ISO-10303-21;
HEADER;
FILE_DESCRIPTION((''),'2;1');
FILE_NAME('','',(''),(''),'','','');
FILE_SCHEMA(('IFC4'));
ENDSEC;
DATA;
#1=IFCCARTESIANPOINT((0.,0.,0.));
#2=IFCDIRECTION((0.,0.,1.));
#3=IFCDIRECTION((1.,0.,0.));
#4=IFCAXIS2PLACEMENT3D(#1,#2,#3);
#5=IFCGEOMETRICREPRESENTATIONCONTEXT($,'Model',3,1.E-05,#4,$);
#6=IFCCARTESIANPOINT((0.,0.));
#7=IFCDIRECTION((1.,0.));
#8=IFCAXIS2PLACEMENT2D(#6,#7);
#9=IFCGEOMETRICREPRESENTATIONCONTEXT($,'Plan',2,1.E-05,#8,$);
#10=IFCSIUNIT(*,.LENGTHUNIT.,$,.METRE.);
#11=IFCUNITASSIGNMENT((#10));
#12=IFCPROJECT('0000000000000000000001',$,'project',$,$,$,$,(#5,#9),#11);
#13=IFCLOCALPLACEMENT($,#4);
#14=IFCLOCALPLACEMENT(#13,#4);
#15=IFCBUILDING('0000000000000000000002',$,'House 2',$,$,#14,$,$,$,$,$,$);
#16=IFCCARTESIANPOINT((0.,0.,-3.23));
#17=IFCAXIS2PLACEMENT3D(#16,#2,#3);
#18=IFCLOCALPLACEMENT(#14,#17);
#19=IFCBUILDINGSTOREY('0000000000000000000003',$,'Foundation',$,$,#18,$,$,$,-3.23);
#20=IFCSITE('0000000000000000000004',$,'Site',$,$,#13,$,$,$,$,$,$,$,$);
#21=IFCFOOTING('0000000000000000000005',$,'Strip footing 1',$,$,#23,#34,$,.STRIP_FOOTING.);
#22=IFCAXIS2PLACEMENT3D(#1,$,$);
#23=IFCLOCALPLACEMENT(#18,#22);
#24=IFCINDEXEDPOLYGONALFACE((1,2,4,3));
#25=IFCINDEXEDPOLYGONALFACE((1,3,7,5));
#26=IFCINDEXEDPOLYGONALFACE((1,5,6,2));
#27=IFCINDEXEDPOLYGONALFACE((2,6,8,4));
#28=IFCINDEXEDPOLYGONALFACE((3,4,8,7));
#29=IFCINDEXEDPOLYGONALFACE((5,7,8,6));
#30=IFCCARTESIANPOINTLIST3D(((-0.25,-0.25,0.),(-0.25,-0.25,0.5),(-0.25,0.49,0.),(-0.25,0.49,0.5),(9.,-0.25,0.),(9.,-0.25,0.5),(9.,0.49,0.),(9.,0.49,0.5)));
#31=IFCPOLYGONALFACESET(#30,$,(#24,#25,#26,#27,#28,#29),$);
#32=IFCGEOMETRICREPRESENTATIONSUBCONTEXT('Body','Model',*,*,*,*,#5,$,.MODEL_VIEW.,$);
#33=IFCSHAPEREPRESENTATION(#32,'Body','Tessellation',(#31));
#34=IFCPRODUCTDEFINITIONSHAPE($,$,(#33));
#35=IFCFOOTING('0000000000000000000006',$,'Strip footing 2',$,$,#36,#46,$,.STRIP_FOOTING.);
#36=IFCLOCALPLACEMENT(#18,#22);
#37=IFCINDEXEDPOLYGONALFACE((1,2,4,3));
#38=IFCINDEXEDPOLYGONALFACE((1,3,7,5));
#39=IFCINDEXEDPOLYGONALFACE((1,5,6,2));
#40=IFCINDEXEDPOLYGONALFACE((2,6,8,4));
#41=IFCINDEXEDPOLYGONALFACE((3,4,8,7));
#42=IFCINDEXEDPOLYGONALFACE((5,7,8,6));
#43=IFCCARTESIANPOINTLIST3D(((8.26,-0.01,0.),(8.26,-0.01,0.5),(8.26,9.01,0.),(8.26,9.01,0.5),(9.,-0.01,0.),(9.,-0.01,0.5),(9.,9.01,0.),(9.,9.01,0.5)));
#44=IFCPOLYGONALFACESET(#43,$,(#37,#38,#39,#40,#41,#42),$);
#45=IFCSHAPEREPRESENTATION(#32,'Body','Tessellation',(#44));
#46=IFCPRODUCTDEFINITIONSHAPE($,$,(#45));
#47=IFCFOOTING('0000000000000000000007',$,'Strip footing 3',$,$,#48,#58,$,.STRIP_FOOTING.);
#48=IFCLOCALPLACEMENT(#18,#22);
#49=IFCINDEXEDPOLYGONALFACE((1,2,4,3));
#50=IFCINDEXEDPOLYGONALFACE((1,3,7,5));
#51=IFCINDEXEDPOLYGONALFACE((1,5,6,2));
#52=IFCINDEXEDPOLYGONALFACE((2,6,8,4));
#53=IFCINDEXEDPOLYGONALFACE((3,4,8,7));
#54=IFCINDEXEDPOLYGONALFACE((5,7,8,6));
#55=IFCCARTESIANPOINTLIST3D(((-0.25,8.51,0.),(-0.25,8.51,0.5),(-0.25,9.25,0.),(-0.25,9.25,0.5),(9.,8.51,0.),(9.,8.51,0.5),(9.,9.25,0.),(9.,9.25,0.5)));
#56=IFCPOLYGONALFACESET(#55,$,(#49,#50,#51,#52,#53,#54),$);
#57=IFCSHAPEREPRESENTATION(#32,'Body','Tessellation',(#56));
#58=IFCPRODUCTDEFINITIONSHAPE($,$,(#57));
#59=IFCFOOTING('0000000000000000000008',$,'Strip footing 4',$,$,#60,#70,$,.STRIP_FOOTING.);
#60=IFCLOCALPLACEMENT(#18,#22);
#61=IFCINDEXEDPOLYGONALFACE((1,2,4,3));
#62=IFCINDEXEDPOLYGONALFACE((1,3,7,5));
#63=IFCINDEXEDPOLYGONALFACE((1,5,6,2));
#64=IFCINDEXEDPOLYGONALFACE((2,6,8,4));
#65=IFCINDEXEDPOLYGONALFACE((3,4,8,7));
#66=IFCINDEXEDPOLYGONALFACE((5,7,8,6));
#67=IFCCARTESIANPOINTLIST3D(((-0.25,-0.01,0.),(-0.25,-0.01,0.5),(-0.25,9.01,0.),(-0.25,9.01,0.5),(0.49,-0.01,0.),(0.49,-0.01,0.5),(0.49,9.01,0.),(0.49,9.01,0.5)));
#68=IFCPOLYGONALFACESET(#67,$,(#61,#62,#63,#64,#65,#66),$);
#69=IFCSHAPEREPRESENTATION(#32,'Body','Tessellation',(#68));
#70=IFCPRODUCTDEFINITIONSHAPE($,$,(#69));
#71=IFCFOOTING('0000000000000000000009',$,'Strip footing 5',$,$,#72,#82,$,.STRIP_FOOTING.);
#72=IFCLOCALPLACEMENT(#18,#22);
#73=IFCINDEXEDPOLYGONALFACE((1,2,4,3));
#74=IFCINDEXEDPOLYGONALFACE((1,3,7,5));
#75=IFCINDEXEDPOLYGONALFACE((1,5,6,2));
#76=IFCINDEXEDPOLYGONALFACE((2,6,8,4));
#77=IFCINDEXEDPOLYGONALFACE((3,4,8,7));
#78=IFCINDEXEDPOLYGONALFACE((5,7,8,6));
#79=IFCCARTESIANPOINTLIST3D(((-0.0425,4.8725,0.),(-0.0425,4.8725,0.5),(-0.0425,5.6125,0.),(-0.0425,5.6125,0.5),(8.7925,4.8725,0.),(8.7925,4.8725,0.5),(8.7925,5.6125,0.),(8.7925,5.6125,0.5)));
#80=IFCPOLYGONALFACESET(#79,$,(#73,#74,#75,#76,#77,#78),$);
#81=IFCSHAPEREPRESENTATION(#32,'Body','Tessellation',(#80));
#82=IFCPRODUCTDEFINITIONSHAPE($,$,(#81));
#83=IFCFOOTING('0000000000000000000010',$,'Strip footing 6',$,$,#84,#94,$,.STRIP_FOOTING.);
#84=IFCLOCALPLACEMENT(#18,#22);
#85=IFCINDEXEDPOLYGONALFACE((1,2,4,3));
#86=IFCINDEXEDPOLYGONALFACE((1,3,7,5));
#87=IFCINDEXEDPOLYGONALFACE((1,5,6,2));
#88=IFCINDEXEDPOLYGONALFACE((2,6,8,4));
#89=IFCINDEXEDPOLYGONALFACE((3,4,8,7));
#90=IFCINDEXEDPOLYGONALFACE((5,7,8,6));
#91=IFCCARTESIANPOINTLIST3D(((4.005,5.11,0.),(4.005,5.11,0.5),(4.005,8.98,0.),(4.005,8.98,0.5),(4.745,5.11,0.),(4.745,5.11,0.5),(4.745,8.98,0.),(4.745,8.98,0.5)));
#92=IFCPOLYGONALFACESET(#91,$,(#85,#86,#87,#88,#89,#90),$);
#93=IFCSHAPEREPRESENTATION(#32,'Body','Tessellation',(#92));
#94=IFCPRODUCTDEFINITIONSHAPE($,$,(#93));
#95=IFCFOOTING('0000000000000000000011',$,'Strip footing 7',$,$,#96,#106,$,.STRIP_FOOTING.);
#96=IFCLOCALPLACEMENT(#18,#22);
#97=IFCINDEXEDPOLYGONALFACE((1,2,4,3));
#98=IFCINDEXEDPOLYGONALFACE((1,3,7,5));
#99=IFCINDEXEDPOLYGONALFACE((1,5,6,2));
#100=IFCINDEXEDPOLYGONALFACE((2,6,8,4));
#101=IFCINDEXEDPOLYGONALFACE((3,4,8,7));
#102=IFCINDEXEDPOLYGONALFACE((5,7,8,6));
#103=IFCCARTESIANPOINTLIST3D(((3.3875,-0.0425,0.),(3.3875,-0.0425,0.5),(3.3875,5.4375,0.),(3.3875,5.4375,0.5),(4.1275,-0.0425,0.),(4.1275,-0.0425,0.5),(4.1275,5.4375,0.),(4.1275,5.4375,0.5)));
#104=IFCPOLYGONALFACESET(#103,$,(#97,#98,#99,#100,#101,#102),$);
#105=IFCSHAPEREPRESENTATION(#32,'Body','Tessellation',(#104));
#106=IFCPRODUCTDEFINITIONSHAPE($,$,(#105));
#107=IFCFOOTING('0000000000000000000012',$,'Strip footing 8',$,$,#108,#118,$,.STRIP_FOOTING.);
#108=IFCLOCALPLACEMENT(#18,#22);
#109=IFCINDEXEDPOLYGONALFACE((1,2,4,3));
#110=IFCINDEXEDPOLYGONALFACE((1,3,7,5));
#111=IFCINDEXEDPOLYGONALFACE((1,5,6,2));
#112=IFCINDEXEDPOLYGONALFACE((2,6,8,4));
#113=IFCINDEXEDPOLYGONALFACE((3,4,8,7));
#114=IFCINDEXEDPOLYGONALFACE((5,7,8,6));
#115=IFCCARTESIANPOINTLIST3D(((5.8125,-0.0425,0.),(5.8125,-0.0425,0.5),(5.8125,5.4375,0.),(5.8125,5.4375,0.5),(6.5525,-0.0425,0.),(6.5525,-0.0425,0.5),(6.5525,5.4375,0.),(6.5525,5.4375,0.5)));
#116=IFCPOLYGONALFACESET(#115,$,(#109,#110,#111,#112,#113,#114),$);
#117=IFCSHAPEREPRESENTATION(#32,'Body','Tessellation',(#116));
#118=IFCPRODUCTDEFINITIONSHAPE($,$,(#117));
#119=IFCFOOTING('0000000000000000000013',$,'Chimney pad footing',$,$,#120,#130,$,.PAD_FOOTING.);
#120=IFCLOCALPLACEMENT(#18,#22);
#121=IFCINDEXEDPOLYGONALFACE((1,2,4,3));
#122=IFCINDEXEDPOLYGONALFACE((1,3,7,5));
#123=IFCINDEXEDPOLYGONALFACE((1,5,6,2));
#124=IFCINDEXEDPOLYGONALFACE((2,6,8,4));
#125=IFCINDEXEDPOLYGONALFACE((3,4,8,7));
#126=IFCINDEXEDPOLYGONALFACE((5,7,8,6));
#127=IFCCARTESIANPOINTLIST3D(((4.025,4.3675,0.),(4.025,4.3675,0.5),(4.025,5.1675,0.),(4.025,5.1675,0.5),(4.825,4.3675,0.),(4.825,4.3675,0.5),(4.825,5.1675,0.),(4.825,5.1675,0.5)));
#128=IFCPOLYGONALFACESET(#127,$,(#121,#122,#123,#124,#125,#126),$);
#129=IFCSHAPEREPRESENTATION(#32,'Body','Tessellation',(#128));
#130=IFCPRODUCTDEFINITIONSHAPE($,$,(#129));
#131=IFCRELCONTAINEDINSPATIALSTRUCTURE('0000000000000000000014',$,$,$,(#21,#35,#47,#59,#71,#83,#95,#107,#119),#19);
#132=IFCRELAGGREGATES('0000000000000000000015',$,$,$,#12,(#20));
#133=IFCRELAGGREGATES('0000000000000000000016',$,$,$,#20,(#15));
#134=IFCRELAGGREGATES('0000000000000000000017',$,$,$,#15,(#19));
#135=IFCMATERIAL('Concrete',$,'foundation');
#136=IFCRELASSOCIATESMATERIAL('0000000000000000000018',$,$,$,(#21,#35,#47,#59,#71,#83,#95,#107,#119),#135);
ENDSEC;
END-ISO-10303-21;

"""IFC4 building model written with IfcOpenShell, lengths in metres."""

from ifc_helpers import new_model, si_unit, frame, origin_with_axes, origin_2d_with_axis, place, context, subcontext, project, spatial, indexed_curve, outline, extrude, material, element, save


model = new_model("IFC4")

# Units and contexts
model_context = context("Model", 3, precision=1e-05, world=origin_with_axes())
plan_context = context("Plan", 2, precision=1e-05, world=origin_2d_with_axis())
body_context = subcontext(model_context, "Body", "Model", "MODEL_VIEW")
ifc_project = project(units=[si_unit("LENGTHUNIT", "METRE")], contexts=[model_context, plan_context])

# Site, building, storey
site_placement = place(None, origin_with_axes())
site = spatial("IfcSite", under=ifc_project, at=site_placement, Name="Site")
building_placement = place(site_placement, origin_with_axes())
building = spatial("IfcBuilding", under=site, at=building_placement, Name="House 2")
storey_placement = place(building_placement, frame((0.0, 0.0, -3.23), z_axis=(0.0, 0.0, 1.0), x_axis=(1.0, 0.0, 0.0)))
storey = spatial("IfcBuildingStorey", under=building, at=storey_placement, Name="Foundation", Elevation=-3.23)

# Footings
ifc_material = material(Name="Concrete", Category="foundation")
footing_1_placement = place(storey_placement, frame((-0.25, 0.12, 0.0), z_axis=(0.0, 0.0, 1.0), x_axis=(1.0, 0.0, 0.0)))
element("IfcFooting", 1, at=footing_1_placement, inside=storey, material=ifc_material, Name="Strip footing 1", PredefinedType="STRIP_FOOTING", context=body_context, shape_type="SweptSolid", body=[
    extrude(outline(indexed_curve([(0.0, 0.0), (0.0, 0.74), (9.25, 0.74), (9.25, 0.0), (0.0, 0.0)], self_intersect=False)), frame((0.0, -0.37, 0.0), z_axis=(0.0, 0.0, 1.0), x_axis=(1.0, 0.0, 0.0)), (0.0, 0.0, 1.0), 0.5),
])
footing_2_placement = place(storey_placement, frame((8.63, -0.01, 0.0), z_axis=(0.0, 0.0, 1.0), x_axis=(0.0, 1.0, 0.0)))
element("IfcFooting", 2, at=footing_2_placement, inside=storey, material=ifc_material, Name="Strip footing 2", PredefinedType="STRIP_FOOTING", context=body_context, shape_type="SweptSolid", body=[
    extrude(outline(indexed_curve([(0.0, 0.0), (0.0, 0.74), (9.02, 0.74), (9.02, 0.0), (0.0, 0.0)], self_intersect=False)), frame((0.0, -0.37, 0.0), z_axis=(0.0, 0.0, 1.0), x_axis=(1.0, 0.0, 0.0)), (0.0, 0.0, 1.0), 0.5),
])
footing_3_placement = place(storey_placement, frame((9.0, 8.88, 0.0), z_axis=(0.0, 0.0, 1.0), x_axis=(-1.0, 0.0, 0.0)))
element("IfcFooting", 3, at=footing_3_placement, inside=storey, material=ifc_material, Name="Strip footing 3", PredefinedType="STRIP_FOOTING", context=body_context, shape_type="SweptSolid", body=[
    extrude(outline(indexed_curve([(0.0, 0.0), (0.0, 0.74), (9.25, 0.74), (9.25, 0.0), (0.0, 0.0)], self_intersect=False)), frame((0.0, -0.37, 0.0), z_axis=(0.0, 0.0, 1.0), x_axis=(1.0, 0.0, 0.0)), (0.0, 0.0, 1.0), 0.5),
])
footing_4_placement = place(storey_placement, frame((0.12, 9.01, 0.0), z_axis=(0.0, 0.0, 1.0), x_axis=(0.0, -1.0, 0.0)))
element("IfcFooting", 4, at=footing_4_placement, inside=storey, material=ifc_material, Name="Strip footing 4", PredefinedType="STRIP_FOOTING", context=body_context, shape_type="SweptSolid", body=[
    extrude(outline(indexed_curve([(0.0, 0.0), (0.0, 0.74), (9.02, 0.74), (9.02, 0.0), (0.0, 0.0)], self_intersect=False)), frame((0.0, -0.37, 0.0), z_axis=(0.0, 0.0, 1.0), x_axis=(1.0, 0.0, 0.0)), (0.0, 0.0, 1.0), 0.5),
])
footing_5_placement = place(storey_placement, frame((-0.0425, 5.2425, 0.0), z_axis=(0.0, 0.0, 1.0), x_axis=(1.0, 0.0, 0.0)))
element("IfcFooting", 5, at=footing_5_placement, inside=storey, material=ifc_material, Name="Strip footing 5", PredefinedType="STRIP_FOOTING", context=body_context, shape_type="SweptSolid", body=[
    extrude(outline(indexed_curve([(0.0, 0.0), (0.0, 0.74), (8.835, 0.74), (8.835, 0.0), (0.0, 0.0)], self_intersect=False)), frame((0.0, -0.37, 0.0), z_axis=(0.0, 0.0, 1.0), x_axis=(1.0, 0.0, 0.0)), (0.0, 0.0, 1.0), 0.5),
])
footing_6_placement = place(storey_placement, frame((4.375, 5.11, 0.0), z_axis=(0.0, 0.0, 1.0), x_axis=(0.0, 1.0, 0.0)))
element("IfcFooting", 6, at=footing_6_placement, inside=storey, material=ifc_material, Name="Strip footing 6", PredefinedType="STRIP_FOOTING", context=body_context, shape_type="SweptSolid", body=[
    extrude(outline(indexed_curve([(0.0, 0.0), (0.0, 0.74), (3.87, 0.74), (3.87, 0.0), (0.0, 0.0)], self_intersect=False)), frame((0.0, -0.37, 0.0), z_axis=(0.0, 0.0, 1.0), x_axis=(1.0, 0.0, 0.0)), (0.0, 0.0, 1.0), 0.5),
])
for number, where, z_axis, x_axis, name in (
    (7, (3.7575, -0.0425, 0.0), (0.0, 0.0, 1.0), (0.0, 1.0, 0.0), "Strip footing 7"),
    (8, (6.1825, -0.0425, 0.0), (0.0, 0.0, 1.0), (0.0, 1.0, 0.0), "Strip footing 8"),
):
    element("IfcFooting", number, at=place(storey_placement, frame(where, z_axis=z_axis, x_axis=x_axis)), inside=storey, material=ifc_material, Name=name, PredefinedType="STRIP_FOOTING", context=body_context, shape_type="SweptSolid", body=[
        extrude(outline(indexed_curve([(0.0, 0.0), (0.0, 0.74), (5.48, 0.74), (5.48, 0.0), (0.0, 0.0)], self_intersect=False)), frame((0.0, -0.37, 0.0), z_axis=(0.0, 0.0, 1.0), x_axis=(1.0, 0.0, 0.0)), (0.0, 0.0, 1.0), 0.5),
    ])
footing_7_placement = place(storey_placement, frame((4.425, 4.7675, 0.0), z_axis=(0.0, 0.0, 1.0), x_axis=(1.0, 0.0, 0.0)))
element("IfcFooting", 9, at=footing_7_placement, inside=storey, material=ifc_material, Name="Chimney pad footing", PredefinedType="PAD_FOOTING", context=body_context, shape_type="SweptSolid", body=[
    extrude(outline(indexed_curve([(-0.4, -0.4), (0.4, -0.4), (0.4, 0.4), (-0.4, 0.4), (-0.4, -0.4)])), None, (0.0, 0.0, 1.0), 0.5),
])

save(model, "model.ifc")
